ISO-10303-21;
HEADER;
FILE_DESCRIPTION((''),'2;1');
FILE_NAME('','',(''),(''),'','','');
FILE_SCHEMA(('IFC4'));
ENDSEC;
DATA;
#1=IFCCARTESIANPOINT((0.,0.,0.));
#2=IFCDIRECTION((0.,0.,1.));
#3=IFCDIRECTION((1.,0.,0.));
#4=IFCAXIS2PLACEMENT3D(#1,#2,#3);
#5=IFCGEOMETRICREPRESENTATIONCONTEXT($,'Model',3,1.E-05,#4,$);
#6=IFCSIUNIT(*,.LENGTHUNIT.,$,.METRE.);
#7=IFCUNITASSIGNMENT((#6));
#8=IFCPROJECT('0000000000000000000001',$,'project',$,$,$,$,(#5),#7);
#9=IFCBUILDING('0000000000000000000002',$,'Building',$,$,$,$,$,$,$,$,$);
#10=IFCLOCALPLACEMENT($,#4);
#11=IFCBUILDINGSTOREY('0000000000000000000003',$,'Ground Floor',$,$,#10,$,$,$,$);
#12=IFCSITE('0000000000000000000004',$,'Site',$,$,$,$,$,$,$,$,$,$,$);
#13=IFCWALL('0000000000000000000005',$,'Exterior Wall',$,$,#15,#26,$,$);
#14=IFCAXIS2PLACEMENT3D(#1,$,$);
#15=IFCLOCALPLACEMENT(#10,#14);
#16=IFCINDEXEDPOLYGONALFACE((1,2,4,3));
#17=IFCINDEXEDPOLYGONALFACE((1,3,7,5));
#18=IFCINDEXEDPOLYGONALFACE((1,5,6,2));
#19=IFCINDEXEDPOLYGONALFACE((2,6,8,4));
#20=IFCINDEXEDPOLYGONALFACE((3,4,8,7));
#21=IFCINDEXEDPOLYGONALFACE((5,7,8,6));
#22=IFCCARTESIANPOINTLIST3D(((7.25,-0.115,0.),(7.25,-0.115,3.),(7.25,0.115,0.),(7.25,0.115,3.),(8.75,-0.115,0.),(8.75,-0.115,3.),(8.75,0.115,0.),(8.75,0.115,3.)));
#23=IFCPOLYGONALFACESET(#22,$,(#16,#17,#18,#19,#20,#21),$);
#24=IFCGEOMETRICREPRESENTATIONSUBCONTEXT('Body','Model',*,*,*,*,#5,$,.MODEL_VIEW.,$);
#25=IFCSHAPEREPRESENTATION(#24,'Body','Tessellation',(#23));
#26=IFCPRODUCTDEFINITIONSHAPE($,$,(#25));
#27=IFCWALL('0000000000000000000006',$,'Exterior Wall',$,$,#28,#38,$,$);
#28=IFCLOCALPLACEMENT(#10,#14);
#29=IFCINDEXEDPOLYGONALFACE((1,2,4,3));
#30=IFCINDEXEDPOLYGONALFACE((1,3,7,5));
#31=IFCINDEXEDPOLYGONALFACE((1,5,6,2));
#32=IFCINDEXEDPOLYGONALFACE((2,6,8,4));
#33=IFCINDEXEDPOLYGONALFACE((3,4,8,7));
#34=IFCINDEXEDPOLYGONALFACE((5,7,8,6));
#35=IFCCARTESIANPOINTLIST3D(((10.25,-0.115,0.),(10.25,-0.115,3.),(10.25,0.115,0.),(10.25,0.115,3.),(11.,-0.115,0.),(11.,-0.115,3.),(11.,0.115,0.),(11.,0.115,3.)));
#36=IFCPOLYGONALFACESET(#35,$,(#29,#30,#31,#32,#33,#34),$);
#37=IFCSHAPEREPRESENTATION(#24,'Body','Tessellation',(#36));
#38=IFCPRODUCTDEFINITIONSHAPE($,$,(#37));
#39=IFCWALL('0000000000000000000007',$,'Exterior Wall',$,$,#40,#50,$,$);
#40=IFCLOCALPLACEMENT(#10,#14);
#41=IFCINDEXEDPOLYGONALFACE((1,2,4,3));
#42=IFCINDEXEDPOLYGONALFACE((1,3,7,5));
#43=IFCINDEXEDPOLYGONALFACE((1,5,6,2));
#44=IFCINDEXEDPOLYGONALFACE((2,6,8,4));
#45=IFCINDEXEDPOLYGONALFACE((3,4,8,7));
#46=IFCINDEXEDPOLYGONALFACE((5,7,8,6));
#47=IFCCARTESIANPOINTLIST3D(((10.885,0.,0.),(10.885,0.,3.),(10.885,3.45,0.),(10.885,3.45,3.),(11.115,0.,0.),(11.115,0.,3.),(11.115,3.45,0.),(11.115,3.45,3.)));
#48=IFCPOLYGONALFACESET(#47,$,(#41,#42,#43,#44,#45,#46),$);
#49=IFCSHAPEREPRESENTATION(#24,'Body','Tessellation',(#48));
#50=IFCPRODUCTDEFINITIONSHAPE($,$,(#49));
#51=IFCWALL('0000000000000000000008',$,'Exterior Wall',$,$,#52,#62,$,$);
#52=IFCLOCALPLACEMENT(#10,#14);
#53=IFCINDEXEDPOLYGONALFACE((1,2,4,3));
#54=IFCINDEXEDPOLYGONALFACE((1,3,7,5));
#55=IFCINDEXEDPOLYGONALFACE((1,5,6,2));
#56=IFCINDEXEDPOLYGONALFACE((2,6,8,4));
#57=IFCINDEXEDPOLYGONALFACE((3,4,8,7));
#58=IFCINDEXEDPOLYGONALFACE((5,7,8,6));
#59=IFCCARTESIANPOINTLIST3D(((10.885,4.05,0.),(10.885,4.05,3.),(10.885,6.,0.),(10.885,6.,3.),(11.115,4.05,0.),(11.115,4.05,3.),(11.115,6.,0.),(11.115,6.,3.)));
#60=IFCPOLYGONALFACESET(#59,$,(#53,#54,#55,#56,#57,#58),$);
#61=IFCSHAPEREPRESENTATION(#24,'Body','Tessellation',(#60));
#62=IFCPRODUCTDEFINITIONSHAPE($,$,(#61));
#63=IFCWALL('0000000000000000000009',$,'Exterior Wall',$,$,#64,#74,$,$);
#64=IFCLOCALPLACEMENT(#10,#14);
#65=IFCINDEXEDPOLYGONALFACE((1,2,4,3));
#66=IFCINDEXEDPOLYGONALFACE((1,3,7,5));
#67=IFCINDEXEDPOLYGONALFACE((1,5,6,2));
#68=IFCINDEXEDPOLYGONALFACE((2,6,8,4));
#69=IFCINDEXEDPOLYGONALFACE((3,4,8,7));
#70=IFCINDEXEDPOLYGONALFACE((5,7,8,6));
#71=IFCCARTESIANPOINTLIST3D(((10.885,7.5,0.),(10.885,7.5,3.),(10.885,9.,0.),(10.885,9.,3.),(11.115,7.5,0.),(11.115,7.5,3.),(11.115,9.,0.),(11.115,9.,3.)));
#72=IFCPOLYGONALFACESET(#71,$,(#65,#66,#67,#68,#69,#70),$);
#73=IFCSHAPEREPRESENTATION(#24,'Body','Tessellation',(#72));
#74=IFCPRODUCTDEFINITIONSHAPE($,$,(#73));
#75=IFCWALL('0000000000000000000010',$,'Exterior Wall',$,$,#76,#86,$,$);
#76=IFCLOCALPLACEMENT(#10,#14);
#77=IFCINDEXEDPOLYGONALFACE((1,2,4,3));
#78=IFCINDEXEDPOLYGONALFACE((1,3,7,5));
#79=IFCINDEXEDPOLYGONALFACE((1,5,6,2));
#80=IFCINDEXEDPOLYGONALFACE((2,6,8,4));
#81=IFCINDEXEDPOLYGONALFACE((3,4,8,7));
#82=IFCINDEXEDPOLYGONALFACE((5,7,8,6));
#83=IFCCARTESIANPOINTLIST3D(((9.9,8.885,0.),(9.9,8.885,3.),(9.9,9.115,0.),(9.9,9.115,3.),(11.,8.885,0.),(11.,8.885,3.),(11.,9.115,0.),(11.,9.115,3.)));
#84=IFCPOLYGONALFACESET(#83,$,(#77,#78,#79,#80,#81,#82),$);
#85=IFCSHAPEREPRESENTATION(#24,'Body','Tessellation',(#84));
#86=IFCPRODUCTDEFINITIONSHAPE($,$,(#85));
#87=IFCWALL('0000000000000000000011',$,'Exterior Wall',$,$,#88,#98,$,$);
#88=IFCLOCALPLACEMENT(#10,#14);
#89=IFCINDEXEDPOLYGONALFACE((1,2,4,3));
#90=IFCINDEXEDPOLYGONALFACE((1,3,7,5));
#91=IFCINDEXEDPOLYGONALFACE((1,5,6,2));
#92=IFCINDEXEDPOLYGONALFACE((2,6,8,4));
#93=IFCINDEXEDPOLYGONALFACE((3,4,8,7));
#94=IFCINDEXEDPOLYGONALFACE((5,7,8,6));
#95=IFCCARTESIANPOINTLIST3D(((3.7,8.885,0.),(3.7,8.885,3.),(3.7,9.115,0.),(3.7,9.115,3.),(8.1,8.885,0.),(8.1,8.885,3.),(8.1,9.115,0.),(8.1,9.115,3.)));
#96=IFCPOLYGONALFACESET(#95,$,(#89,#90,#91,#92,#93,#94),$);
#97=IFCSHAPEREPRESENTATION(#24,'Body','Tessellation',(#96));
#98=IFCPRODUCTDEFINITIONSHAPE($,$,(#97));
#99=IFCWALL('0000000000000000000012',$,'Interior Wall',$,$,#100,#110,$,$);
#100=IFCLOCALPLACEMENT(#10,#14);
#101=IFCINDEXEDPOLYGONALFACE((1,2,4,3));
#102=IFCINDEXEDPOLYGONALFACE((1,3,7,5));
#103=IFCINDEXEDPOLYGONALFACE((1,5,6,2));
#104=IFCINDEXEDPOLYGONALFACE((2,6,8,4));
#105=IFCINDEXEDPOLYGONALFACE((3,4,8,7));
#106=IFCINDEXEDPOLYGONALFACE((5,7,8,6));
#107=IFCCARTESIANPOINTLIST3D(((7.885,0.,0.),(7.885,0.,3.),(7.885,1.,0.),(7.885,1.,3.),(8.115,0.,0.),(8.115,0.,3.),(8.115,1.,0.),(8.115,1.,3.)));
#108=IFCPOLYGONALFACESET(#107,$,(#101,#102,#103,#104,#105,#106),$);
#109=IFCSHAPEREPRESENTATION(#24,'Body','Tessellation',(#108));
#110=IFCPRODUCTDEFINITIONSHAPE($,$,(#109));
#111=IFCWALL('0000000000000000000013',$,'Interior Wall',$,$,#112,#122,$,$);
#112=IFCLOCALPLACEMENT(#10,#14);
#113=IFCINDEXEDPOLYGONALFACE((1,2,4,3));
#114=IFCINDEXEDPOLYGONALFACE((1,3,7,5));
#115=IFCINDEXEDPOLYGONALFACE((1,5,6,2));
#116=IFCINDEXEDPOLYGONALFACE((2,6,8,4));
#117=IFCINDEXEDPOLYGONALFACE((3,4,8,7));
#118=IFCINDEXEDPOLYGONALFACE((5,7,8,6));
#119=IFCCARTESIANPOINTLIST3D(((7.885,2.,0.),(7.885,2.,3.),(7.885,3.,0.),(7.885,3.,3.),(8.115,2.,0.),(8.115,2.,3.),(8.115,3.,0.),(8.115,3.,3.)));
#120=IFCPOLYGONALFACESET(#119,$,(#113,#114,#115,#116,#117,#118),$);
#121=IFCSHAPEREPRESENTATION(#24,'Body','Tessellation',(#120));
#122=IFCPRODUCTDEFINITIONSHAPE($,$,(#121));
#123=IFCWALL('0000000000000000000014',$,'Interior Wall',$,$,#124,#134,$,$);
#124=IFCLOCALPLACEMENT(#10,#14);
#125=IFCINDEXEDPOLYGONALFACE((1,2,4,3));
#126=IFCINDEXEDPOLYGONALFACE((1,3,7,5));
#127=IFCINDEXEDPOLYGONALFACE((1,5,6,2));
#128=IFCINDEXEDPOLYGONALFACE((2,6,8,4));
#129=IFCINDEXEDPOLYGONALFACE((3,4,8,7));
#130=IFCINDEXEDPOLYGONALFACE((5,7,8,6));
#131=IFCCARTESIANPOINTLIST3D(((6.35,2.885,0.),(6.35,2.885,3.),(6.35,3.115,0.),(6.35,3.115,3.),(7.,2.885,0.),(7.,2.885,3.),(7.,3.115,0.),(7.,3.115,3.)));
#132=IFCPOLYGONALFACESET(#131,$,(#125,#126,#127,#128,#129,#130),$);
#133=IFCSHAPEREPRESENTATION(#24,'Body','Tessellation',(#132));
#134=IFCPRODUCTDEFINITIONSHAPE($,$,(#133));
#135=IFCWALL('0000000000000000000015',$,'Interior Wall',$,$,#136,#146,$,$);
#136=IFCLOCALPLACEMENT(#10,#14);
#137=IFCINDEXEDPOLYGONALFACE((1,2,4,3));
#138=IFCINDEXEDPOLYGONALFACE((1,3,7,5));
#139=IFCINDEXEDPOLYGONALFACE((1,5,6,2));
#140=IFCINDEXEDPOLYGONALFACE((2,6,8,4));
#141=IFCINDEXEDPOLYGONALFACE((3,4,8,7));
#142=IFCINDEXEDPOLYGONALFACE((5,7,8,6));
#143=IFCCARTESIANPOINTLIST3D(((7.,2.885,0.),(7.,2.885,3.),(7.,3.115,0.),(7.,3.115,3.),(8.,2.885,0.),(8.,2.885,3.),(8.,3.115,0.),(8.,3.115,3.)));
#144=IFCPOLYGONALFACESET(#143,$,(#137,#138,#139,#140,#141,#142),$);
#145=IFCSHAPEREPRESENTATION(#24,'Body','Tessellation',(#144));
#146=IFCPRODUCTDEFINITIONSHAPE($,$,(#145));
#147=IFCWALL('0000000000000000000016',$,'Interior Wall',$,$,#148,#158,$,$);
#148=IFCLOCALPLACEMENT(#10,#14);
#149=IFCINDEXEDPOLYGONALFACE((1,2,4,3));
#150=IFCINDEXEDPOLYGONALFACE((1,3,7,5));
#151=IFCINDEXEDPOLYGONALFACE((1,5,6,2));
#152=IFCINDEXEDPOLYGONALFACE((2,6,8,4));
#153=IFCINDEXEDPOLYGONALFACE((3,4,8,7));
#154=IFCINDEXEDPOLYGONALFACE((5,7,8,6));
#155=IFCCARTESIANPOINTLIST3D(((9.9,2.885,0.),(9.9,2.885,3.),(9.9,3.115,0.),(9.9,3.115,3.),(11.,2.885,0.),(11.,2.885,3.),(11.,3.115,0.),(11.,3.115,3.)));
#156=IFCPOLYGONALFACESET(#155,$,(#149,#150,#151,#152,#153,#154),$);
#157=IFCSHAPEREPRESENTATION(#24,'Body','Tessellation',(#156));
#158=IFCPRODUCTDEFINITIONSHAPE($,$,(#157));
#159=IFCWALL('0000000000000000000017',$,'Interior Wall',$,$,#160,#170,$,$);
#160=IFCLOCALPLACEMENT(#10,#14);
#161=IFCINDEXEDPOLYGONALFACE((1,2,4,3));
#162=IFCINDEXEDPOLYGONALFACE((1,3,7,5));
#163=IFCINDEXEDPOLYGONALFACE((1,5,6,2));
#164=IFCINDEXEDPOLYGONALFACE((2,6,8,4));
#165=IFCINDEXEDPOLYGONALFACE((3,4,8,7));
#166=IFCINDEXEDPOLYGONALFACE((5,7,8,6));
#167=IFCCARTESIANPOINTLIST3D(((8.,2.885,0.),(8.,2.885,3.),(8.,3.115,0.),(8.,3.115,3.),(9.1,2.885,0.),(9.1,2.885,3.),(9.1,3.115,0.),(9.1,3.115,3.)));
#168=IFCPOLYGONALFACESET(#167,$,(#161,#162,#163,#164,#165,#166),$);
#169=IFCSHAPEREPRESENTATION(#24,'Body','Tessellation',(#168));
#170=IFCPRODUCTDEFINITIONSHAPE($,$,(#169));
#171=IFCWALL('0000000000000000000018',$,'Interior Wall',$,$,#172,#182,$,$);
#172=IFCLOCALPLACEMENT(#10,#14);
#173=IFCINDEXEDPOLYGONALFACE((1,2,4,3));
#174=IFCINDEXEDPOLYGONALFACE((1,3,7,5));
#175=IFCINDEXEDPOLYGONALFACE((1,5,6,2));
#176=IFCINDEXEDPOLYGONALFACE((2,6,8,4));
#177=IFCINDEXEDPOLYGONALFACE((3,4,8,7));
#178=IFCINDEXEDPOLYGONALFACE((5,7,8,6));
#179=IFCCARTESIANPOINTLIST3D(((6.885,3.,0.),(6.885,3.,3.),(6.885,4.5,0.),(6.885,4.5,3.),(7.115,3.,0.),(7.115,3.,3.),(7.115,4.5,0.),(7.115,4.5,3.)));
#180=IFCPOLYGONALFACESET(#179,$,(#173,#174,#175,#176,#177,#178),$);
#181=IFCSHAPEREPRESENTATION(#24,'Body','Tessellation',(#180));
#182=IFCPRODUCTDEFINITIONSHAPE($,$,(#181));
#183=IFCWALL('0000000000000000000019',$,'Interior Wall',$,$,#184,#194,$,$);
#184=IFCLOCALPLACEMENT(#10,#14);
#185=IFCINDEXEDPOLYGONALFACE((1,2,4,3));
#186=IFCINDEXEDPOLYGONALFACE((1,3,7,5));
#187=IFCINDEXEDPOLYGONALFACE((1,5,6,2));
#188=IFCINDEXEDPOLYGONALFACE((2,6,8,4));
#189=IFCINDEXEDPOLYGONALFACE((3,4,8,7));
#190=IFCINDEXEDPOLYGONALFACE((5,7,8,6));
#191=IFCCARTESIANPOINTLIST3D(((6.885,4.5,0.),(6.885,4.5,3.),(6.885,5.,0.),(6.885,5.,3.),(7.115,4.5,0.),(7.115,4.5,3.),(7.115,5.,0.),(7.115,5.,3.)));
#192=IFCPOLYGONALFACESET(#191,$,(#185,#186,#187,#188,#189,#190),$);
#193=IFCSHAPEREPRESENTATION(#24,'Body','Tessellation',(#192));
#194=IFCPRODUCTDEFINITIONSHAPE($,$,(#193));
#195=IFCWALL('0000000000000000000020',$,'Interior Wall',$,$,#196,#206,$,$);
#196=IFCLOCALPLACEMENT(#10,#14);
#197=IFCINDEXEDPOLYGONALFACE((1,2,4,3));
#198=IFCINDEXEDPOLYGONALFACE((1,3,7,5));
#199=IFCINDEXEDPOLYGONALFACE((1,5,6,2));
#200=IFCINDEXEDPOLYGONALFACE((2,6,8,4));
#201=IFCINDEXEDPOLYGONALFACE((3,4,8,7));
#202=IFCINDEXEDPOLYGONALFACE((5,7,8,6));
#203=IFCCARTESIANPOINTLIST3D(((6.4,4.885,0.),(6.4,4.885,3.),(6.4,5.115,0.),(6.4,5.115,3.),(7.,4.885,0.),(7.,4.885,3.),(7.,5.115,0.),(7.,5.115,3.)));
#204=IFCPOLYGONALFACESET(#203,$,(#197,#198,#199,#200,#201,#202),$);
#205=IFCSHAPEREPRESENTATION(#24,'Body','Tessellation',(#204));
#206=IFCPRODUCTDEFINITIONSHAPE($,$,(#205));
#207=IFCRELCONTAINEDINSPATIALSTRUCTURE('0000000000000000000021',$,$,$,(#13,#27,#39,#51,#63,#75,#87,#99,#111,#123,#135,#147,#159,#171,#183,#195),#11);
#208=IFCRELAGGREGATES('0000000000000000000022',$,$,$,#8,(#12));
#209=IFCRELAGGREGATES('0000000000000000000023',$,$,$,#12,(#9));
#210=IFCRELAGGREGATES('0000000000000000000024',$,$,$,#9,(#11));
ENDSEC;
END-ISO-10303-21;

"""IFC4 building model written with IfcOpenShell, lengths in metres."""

from ifc_helpers import new_model, si_unit, frame, origin_with_axes, place, context, subcontext, project, spatial, indexed_curve, outline, extrude, element, save


model = new_model("IFC4")

# Units and contexts
model_context = context("Model", 3, precision=1e-05, world=origin_with_axes())
body_context = subcontext(model_context, "Body", "Model", "MODEL_VIEW")
ifc_project = project(units=[si_unit("LENGTHUNIT", "METRE")], contexts=[model_context])

# Site, building, storey
site = spatial("IfcSite", under=ifc_project, Name="Site")
building = spatial("IfcBuilding", under=site, Name="Building")
storey_placement = place(None, origin_with_axes())
storey = spatial("IfcBuildingStorey", under=building, at=storey_placement, Name="Ground Floor")

# Walls
wall_1_placement = place(storey_placement, frame((7.25, 0.0, 0.0), z_axis=(0.0, 0.0, 1.0), x_axis=(1.0, 0.0, 0.0)))
element("IfcWall", 1, at=wall_1_placement, inside=storey, Name="Exterior Wall", context=body_context, shape_type="SweptSolid", body=[
    extrude(outline(indexed_curve([(0.0, 0.0), (0.0, 0.23), (1.5, 0.23), (1.5, 0.0), (0.0, 0.0)], self_intersect=False)), frame((0.0, -0.115, 0.0), z_axis=(0.0, 0.0, 1.0), x_axis=(1.0, 0.0, 0.0)), (0.0, 0.0, 1.0), 3.0),
])
wall_2_placement = place(storey_placement, frame((10.25, 0.0, 0.0), z_axis=(0.0, 0.0, 1.0), x_axis=(1.0, 0.0, 0.0)))
element("IfcWall", 2, at=wall_2_placement, inside=storey, Name="Exterior Wall", context=body_context, shape_type="SweptSolid", body=[
    extrude(outline(indexed_curve([(0.0, 0.0), (0.0, 0.23), (0.75, 0.23), (0.75, 0.0), (0.0, 0.0)], self_intersect=False)), frame((0.0, -0.115, 0.0), z_axis=(0.0, 0.0, 1.0), x_axis=(1.0, 0.0, 0.0)), (0.0, 0.0, 1.0), 3.0),
])
wall_3_placement = place(storey_placement, frame((11.0, 0.0, 0.0), z_axis=(0.0, 0.0, 1.0), x_axis=(0.0, 1.0, 0.0)))
element("IfcWall", 3, at=wall_3_placement, inside=storey, Name="Exterior Wall", context=body_context, shape_type="SweptSolid", body=[
    extrude(outline(indexed_curve([(0.0, 0.0), (0.0, 0.23), (3.45, 0.23), (3.45, 0.0), (0.0, 0.0)], self_intersect=False)), frame((0.0, -0.115, 0.0), z_axis=(0.0, 0.0, 1.0), x_axis=(1.0, 0.0, 0.0)), (0.0, 0.0, 1.0), 3.0),
])
wall_4_placement = place(storey_placement, frame((11.0, 4.05, 0.0), z_axis=(0.0, 0.0, 1.0), x_axis=(0.0, 1.0, 0.0)))
element("IfcWall", 4, at=wall_4_placement, inside=storey, Name="Exterior Wall", context=body_context, shape_type="SweptSolid", body=[
    extrude(outline(indexed_curve([(0.0, 0.0), (0.0, 0.23), (1.95, 0.23), (1.95, 0.0), (0.0, 0.0)], self_intersect=False)), frame((0.0, -0.115, 0.0), z_axis=(0.0, 0.0, 1.0), x_axis=(1.0, 0.0, 0.0)), (0.0, 0.0, 1.0), 3.0),
])
wall_5_placement = place(storey_placement, frame((11.0, 7.5, 0.0), z_axis=(0.0, 0.0, 1.0), x_axis=(0.0, 1.0, 0.0)))
element("IfcWall", 5, at=wall_5_placement, inside=storey, Name="Exterior Wall", context=body_context, shape_type="SweptSolid", body=[
    extrude(outline(indexed_curve([(0.0, 0.0), (0.0, 0.23), (1.5, 0.23), (1.5, 0.0), (0.0, 0.0)], self_intersect=False)), frame((0.0, -0.115, 0.0), z_axis=(0.0, 0.0, 1.0), x_axis=(1.0, 0.0, 0.0)), (0.0, 0.0, 1.0), 3.0),
])
wall_6_placement = place(storey_placement, frame((11.0, 9.0, 0.0), z_axis=(0.0, 0.0, 1.0), x_axis=(-1.0, 0.0, 0.0)))
element("IfcWall", 6, at=wall_6_placement, inside=storey, Name="Exterior Wall", context=body_context, shape_type="SweptSolid", body=[
    extrude(outline(indexed_curve([(0.0, 0.0), (0.0, 0.23), (1.1, 0.23), (1.1, 0.0), (0.0, 0.0)], self_intersect=False)), frame((0.0, -0.115, 0.0), z_axis=(0.0, 0.0, 1.0), x_axis=(1.0, 0.0, 0.0)), (0.0, 0.0, 1.0), 3.0),
])
wall_7_placement = place(storey_placement, frame((8.1, 9.0, 0.0), z_axis=(0.0, 0.0, 1.0), x_axis=(-1.0, 0.0, 0.0)))
element("IfcWall", 7, at=wall_7_placement, inside=storey, Name="Exterior Wall", context=body_context, shape_type="SweptSolid", body=[
    extrude(outline(indexed_curve([(0.0, 0.0), (0.0, 0.23), (4.4, 0.23), (4.4, 0.0), (0.0, 0.0)], self_intersect=False)), frame((0.0, -0.115, 0.0), z_axis=(0.0, 0.0, 1.0), x_axis=(1.0, 0.0, 0.0)), (0.0, 0.0, 1.0), 3.0),
])
for number, where, z_axis, x_axis, name in (
    (8, (8.0, 0.0, 0.0), (0.0, 0.0, 1.0), (0.0, 1.0, 0.0), "Interior Wall"),
    (9, (8.0, 2.0, 0.0), (0.0, 0.0, 1.0), (0.0, 1.0, 0.0), "Interior Wall"),
):
    element("IfcWall", number, at=place(storey_placement, frame(where, z_axis=z_axis, x_axis=x_axis)), inside=storey, Name=name, context=body_context, shape_type="SweptSolid", body=[
        extrude(outline(indexed_curve([(0.0, 0.0), (0.0, 0.23), (1.0, 0.23), (1.0, 0.0), (0.0, 0.0)], self_intersect=False)), frame((0.0, -0.115, 0.0), z_axis=(0.0, 0.0, 1.0), x_axis=(1.0, 0.0, 0.0)), (0.0, 0.0, 1.0), 3.0),
    ])
wall_8_placement = place(storey_placement, frame((7.0, 3.0, 0.0), z_axis=(0.0, 0.0, 1.0), x_axis=(-1.0, 0.0, 0.0)))
element("IfcWall", 10, at=wall_8_placement, inside=storey, Name="Interior Wall", context=body_context, shape_type="SweptSolid", body=[
    extrude(outline(indexed_curve([(0.0, 0.0), (0.0, 0.23), (0.65, 0.23), (0.65, 0.0), (0.0, 0.0)], self_intersect=False)), frame((0.0, -0.115, 0.0), z_axis=(0.0, 0.0, 1.0), x_axis=(1.0, 0.0, 0.0)), (0.0, 0.0, 1.0), 3.0),
])
wall_9_placement = place(storey_placement, frame((8.0, 3.0, 0.0), z_axis=(0.0, 0.0, 1.0), x_axis=(-1.0, 0.0, 0.0)))
element("IfcWall", 11, at=wall_9_placement, inside=storey, Name="Interior Wall", context=body_context, shape_type="SweptSolid", body=[
    extrude(outline(indexed_curve([(0.0, 0.0), (0.0, 0.23), (1.0, 0.23), (1.0, 0.0), (0.0, 0.0)], self_intersect=False)), frame((0.0, -0.115, 0.0), z_axis=(0.0, 0.0, 1.0), x_axis=(1.0, 0.0, 0.0)), (0.0, 0.0, 1.0), 3.0),
])
for number, where, z_axis, x_axis, name in (
    (12, (11.0, 3.0, 0.0), (0.0, 0.0, 1.0), (-1.0, 0.0, 0.0), "Interior Wall"),
    (13, (9.1, 3.0, 0.0), (0.0, 0.0, 1.0), (-1.0, 0.0, 0.0), "Interior Wall"),
):
    element("IfcWall", number, at=place(storey_placement, frame(where, z_axis=z_axis, x_axis=x_axis)), inside=storey, Name=name, context=body_context, shape_type="SweptSolid", body=[
        extrude(outline(indexed_curve([(0.0, 0.0), (0.0, 0.23), (1.1, 0.23), (1.1, 0.0), (0.0, 0.0)], self_intersect=False)), frame((0.0, -0.115, 0.0), z_axis=(0.0, 0.0, 1.0), x_axis=(1.0, 0.0, 0.0)), (0.0, 0.0, 1.0), 3.0),
    ])
wall_10_placement = place(storey_placement, frame((7.0, 3.0, 0.0), z_axis=(0.0, 0.0, 1.0), x_axis=(0.0, 1.0, 0.0)))
element("IfcWall", 14, at=wall_10_placement, inside=storey, Name="Interior Wall", context=body_context, shape_type="SweptSolid", body=[
    extrude(outline(indexed_curve([(0.0, 0.0), (0.0, 0.23), (1.5, 0.23), (1.5, 0.0), (0.0, 0.0)], self_intersect=False)), frame((0.0, -0.115, 0.0), z_axis=(0.0, 0.0, 1.0), x_axis=(1.0, 0.0, 0.0)), (0.0, 0.0, 1.0), 3.0),
])
wall_11_placement = place(storey_placement, frame((7.0, 4.5, 0.0), z_axis=(0.0, 0.0, 1.0), x_axis=(0.0, 1.0, 0.0)))
element("IfcWall", 15, at=wall_11_placement, inside=storey, Name="Interior Wall", context=body_context, shape_type="SweptSolid", body=[
    extrude(outline(indexed_curve([(0.0, 0.0), (0.0, 0.23), (0.5, 0.23), (0.5, 0.0), (0.0, 0.0)], self_intersect=False)), frame((0.0, -0.115, 0.0), z_axis=(0.0, 0.0, 1.0), x_axis=(1.0, 0.0, 0.0)), (0.0, 0.0, 1.0), 3.0),
])
wall_12_placement = place(storey_placement, frame((7.0, 5.0, 0.0), z_axis=(0.0, 0.0, 1.0), x_axis=(-1.0, 0.0, 0.0)))
element("IfcWall", 16, at=wall_12_placement, inside=storey, Name="Interior Wall", context=body_context, shape_type="SweptSolid", body=[
    extrude(outline(indexed_curve([(0.0, 0.0), (0.0, 0.23), (0.6, 0.23), (0.6, 0.0), (0.0, 0.0)], self_intersect=False)), frame((0.0, -0.115, 0.0), z_axis=(0.0, 0.0, 1.0), x_axis=(1.0, 0.0, 0.0)), (0.0, 0.0, 1.0), 3.0),
])

save(model, "model.ifc")
